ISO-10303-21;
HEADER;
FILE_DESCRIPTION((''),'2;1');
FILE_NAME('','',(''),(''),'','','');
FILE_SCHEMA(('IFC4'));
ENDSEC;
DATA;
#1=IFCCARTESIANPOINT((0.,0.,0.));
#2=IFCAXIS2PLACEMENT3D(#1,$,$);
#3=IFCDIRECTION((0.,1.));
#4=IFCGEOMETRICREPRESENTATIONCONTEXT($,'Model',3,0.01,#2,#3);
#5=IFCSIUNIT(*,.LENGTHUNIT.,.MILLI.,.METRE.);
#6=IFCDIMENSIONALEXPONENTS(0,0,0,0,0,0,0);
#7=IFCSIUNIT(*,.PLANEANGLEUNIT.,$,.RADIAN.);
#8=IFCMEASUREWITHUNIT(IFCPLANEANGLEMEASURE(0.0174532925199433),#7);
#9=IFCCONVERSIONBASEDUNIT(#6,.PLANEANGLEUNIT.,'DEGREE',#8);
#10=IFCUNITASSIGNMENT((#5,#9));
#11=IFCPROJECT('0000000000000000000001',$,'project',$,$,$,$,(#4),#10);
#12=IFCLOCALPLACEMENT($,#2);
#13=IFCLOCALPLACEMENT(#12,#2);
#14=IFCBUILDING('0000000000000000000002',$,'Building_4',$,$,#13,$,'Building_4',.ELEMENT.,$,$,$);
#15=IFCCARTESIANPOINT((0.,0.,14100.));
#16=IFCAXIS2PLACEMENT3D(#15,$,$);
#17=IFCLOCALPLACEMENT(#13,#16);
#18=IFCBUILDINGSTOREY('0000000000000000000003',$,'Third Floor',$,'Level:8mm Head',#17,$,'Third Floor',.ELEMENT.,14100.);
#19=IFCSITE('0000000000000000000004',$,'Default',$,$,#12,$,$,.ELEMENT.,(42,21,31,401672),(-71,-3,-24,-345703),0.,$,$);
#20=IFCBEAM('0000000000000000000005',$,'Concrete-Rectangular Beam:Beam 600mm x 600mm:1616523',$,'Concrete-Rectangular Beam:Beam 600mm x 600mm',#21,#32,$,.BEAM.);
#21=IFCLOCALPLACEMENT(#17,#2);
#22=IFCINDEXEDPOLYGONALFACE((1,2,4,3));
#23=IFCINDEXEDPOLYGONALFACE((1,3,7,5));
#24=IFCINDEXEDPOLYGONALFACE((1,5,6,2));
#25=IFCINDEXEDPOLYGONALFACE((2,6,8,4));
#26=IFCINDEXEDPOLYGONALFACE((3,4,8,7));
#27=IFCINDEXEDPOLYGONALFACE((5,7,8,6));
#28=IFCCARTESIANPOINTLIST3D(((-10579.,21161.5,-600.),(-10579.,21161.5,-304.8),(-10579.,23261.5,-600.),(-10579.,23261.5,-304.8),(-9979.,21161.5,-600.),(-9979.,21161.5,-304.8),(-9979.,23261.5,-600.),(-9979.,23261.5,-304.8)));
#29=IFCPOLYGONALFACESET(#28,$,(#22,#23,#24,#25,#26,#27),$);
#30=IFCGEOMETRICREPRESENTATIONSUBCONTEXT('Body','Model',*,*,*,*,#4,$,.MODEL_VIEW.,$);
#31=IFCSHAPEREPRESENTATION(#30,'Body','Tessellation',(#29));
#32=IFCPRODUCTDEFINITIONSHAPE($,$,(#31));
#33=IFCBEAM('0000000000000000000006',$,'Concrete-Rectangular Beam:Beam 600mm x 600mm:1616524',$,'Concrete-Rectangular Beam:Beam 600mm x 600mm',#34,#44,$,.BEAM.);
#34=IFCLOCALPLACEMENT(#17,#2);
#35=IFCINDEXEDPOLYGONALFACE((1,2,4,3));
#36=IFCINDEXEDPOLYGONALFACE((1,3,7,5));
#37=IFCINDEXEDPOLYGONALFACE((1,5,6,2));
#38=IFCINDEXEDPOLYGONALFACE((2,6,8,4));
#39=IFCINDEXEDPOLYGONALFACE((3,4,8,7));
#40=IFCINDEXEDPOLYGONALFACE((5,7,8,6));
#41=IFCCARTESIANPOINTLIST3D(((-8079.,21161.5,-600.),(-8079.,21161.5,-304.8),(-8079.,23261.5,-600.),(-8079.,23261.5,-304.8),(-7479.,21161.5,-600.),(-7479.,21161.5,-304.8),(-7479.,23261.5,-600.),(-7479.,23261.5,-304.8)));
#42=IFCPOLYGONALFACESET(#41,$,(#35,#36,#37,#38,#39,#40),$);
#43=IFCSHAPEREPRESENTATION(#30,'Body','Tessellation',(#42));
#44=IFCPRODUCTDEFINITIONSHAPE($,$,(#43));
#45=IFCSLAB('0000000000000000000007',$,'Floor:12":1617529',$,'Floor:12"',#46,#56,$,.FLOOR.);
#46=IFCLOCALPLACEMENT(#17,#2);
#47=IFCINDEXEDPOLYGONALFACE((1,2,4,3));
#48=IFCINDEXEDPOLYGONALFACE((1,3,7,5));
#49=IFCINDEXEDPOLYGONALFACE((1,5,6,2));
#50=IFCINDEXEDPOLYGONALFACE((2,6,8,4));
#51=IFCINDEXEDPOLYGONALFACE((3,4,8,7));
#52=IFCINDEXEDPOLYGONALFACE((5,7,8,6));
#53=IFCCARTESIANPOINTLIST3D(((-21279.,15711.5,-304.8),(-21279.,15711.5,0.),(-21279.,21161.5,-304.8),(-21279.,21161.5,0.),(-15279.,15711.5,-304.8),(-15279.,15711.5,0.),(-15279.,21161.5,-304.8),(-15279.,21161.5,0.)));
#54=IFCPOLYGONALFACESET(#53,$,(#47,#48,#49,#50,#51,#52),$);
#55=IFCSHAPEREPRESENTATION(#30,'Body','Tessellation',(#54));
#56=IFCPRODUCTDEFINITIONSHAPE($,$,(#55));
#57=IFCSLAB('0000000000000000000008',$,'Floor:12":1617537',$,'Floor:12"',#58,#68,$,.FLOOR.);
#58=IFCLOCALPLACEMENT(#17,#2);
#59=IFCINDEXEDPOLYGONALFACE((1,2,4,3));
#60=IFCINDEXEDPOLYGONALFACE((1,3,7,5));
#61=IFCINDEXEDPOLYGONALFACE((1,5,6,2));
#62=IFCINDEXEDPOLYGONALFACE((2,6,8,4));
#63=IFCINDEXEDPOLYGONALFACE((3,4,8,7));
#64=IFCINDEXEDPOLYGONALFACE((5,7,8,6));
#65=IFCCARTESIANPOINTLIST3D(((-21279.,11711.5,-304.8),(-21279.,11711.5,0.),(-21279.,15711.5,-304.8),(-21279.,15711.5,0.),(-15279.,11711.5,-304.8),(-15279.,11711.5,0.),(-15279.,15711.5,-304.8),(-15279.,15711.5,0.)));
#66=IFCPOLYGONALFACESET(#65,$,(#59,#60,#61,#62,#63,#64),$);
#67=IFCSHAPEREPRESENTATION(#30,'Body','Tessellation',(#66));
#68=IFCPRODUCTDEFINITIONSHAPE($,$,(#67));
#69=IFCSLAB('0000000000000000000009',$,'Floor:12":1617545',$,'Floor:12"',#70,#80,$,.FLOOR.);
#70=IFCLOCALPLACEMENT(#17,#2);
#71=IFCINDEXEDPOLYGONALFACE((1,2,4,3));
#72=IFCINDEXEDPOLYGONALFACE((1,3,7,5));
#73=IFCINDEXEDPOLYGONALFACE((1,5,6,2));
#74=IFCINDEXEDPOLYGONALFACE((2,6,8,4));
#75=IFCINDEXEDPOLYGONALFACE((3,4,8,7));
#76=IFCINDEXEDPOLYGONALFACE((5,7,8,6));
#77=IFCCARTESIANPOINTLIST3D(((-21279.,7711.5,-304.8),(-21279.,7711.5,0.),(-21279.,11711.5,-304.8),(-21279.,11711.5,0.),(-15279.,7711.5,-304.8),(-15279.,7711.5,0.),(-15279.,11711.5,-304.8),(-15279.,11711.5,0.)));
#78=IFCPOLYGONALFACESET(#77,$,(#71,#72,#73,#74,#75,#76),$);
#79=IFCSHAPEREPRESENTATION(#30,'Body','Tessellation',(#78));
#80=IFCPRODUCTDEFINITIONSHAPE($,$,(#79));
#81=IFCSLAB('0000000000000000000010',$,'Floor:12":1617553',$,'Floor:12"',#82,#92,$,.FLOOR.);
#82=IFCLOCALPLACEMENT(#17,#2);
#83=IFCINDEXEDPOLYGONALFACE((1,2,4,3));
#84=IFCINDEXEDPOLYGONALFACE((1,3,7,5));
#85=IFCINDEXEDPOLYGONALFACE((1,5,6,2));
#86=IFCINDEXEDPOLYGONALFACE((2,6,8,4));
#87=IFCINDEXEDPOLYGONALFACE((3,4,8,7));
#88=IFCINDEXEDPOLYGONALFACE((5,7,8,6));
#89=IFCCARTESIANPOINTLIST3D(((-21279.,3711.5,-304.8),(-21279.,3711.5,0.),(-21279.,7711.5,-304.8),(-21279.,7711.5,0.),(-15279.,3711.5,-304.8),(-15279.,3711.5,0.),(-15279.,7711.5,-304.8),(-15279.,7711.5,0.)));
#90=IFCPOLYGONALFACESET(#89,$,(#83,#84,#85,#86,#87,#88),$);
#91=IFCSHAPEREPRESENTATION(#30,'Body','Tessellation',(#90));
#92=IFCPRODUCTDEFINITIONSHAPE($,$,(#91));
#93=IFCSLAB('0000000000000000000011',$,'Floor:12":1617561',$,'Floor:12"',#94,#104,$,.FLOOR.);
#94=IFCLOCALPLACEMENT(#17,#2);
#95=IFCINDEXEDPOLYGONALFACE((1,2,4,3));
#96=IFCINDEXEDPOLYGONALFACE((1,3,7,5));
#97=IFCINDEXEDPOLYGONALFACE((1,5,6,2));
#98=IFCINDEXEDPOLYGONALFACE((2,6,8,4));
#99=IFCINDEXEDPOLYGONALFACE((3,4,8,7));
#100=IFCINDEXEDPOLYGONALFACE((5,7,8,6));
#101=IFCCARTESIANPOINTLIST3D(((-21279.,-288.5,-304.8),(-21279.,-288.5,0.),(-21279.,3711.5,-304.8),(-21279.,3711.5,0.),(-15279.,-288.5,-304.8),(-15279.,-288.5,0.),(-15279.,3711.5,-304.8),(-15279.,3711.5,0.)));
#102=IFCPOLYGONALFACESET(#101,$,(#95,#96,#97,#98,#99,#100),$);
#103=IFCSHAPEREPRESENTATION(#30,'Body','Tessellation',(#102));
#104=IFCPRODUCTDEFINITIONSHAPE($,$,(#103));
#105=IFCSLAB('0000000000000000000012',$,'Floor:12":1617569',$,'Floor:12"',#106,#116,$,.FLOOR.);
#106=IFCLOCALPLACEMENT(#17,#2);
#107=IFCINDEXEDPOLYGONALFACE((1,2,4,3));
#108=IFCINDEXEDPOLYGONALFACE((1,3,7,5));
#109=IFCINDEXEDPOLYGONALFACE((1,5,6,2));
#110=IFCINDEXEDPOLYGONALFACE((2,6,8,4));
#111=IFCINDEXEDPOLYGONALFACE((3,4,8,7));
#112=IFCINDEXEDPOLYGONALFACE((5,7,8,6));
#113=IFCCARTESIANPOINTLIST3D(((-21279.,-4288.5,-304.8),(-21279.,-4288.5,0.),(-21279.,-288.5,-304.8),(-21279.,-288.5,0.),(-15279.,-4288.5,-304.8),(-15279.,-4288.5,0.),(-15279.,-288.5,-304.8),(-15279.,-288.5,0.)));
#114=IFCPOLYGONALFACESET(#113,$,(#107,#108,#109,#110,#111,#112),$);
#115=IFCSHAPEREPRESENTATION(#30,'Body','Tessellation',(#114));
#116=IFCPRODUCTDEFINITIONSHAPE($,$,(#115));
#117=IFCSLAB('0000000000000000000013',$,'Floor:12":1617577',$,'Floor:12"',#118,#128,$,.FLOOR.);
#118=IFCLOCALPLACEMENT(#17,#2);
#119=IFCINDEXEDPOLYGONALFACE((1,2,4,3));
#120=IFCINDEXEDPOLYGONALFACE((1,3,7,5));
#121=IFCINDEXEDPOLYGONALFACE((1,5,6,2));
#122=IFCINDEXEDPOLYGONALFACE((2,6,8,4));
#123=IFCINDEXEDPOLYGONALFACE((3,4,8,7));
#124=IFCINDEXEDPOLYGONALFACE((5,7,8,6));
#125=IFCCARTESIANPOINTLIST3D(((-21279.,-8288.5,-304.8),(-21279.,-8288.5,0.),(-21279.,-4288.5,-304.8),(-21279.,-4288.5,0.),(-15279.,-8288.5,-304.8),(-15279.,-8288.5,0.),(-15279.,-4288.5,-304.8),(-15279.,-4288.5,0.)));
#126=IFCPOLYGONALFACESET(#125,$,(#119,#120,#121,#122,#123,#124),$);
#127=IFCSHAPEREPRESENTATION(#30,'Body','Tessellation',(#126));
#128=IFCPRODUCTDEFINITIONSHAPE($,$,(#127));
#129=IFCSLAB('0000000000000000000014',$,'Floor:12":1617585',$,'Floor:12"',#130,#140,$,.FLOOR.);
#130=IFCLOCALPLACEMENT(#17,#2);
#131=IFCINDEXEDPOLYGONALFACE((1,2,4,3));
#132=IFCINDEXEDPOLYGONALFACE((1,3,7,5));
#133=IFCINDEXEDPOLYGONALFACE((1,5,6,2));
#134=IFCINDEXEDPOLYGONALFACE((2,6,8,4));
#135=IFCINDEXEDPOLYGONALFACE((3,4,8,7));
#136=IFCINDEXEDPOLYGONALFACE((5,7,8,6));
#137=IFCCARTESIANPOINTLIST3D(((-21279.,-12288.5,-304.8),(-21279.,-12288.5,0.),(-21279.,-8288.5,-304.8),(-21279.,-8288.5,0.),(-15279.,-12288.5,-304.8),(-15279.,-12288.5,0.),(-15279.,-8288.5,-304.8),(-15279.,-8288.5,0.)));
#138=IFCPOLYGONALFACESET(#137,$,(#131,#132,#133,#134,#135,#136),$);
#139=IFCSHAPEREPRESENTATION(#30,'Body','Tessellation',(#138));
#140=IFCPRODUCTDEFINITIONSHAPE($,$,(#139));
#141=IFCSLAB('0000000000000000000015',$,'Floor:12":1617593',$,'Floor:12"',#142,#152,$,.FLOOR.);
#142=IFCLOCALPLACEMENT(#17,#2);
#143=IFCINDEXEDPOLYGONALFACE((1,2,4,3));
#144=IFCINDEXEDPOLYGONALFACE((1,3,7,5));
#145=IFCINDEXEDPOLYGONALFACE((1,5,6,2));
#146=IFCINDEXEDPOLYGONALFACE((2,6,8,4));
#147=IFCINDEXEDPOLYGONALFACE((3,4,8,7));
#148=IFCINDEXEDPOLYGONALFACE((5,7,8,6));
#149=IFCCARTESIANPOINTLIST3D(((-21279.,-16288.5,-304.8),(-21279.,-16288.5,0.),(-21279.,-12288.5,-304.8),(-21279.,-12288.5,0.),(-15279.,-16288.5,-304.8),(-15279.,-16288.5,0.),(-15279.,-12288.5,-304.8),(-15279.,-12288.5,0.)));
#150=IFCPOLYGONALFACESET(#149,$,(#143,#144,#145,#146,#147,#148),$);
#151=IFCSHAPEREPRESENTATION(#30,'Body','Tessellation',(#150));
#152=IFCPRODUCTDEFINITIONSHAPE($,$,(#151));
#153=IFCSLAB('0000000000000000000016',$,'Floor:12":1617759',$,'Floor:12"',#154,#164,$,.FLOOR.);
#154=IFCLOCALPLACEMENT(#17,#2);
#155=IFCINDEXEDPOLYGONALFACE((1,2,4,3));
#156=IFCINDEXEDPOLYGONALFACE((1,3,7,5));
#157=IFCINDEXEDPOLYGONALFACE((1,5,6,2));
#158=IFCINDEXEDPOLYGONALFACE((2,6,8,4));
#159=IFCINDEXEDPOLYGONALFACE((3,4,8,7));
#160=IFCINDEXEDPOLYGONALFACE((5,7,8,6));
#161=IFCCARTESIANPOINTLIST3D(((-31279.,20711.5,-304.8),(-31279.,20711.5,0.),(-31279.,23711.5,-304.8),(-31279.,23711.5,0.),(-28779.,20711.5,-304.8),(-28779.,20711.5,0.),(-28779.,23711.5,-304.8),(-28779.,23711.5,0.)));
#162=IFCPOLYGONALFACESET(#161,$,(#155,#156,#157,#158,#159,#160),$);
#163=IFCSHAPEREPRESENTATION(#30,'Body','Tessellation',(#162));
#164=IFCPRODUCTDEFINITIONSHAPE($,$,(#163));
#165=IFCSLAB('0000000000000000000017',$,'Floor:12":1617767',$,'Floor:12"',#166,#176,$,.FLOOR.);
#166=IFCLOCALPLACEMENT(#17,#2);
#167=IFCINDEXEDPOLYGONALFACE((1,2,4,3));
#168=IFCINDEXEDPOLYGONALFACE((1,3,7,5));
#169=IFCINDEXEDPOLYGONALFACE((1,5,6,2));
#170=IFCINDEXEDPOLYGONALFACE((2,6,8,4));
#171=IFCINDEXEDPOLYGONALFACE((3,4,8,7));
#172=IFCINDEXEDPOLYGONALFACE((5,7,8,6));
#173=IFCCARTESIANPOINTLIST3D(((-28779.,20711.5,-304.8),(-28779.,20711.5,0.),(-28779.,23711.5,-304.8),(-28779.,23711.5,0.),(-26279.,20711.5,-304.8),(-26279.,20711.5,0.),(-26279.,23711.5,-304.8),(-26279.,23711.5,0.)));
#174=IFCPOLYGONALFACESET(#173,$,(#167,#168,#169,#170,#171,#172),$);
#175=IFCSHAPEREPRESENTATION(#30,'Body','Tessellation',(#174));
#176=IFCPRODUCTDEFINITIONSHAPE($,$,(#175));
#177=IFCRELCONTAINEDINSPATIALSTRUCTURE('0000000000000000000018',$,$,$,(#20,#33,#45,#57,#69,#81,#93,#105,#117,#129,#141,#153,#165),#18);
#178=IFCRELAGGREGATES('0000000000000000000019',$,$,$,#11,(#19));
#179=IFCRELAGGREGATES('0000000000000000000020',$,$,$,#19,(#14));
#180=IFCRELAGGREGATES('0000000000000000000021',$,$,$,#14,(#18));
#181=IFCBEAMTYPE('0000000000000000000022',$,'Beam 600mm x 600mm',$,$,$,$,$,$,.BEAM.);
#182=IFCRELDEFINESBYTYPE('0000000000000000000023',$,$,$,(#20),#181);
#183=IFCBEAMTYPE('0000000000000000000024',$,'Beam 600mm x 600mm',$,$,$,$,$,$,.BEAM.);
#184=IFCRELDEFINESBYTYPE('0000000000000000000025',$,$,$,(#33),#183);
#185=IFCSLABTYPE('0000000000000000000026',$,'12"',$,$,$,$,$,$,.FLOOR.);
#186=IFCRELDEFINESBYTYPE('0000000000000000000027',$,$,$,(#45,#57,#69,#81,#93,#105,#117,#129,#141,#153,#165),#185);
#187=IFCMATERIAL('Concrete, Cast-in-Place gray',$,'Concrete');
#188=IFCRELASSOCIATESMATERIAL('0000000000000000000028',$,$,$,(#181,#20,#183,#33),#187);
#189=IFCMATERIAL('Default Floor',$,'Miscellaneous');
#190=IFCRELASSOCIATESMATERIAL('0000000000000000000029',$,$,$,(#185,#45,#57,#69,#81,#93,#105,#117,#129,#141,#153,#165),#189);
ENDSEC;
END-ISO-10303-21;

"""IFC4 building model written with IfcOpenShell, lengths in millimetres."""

from ifc_helpers import new_model, entity, si_unit, converted_unit, direction, frame, origin, place, context, subcontext, project, spatial, indexed_curve, outline, extrude, source, transform, mapped, material, type_object, type_shapes, element, save


model = new_model("IFC4")

# Units and contexts
model_context = context("Model", 3, precision=0.01, world=origin(), true_north=direction((0.0, 1.0)))
body_context = subcontext(model_context, "Body", "Model", "MODEL_VIEW")
ifc_project = project(units=[si_unit("LENGTHUNIT", "METRE", prefix="MILLI"), converted_unit("PLANEANGLEUNIT", "DEGREE", entity("IfcPlaneAngleMeasure", 0.0174532925199433), si_unit("PLANEANGLEUNIT", "RADIAN"), dimensions=[0, 0, 0, 0, 0, 0, 0])], contexts=[model_context])

# Site, building, storey
site_placement = place(None, origin())
site = spatial("IfcSite", under=ifc_project, at=site_placement, Name="Default", CompositionType="ELEMENT", RefLatitude=(42, 21, 31, 401672), RefLongitude=(-71, -3, -24, -345703), RefElevation=0.0)
building_placement = place(site_placement, origin())
building = spatial("IfcBuilding", under=site, at=building_placement, Name="Building_4", LongName="Building_4", CompositionType="ELEMENT")
storey_placement = place(building_placement, frame((0.0, 0.0, 14100.0)))
storey = spatial("IfcBuildingStorey", under=building, at=storey_placement, Name="Third Floor", ObjectType="Level:8mm Head", LongName="Third Floor", CompositionType="ELEMENT", Elevation=14100.0)

# Beams
ifc_material_1 = material(Name="Concrete, Cast-in-Place gray", Category="Concrete")
beam_type_1 = type_object("IfcBeamType", Name="Beam 600mm x 600mm", PredefinedType="BEAM", material=ifc_material_1)
shared_shape_1 = source(origin(), body_context, "Body", "SweptSolid", [
    extrude(outline(indexed_curve([(-300.0, -147.6), (300.0, -147.6), (300.0, 147.6), (-300.0, 147.6), (-300.0, -147.6)], self_intersect=False)), frame((-10279.0, 23261.5, 13647.6), z_axis=(0.0, -1.0, 0.0), x_axis=(-1.0, 0.0, 0.0)), (0.0, 0.0, 1.0), 2100.0),
])
type_shapes(beam_type_1, [shared_shape_1])
beam_1_placement = place(storey_placement, frame((0.0, 0.0, -14100.0)))
element("IfcBeam", 1, at=beam_1_placement, inside=storey, type_object=beam_type_1, material=ifc_material_1, Name="Concrete-Rectangular Beam:Beam 600mm x 600mm:1616523", ObjectType="Concrete-Rectangular Beam:Beam 600mm x 600mm", PredefinedType="BEAM", context=body_context, shape_type="MappedRepresentation", body=[
    mapped(shared_shape_1, transform((0.0, 0.0, 0.0), scale=1.0)),
])
beam_type_2 = type_object("IfcBeamType", Name="Beam 600mm x 600mm", PredefinedType="BEAM", material=ifc_material_1)
shared_shape_2 = source(origin(), body_context, "Body", "SweptSolid", [
    extrude(outline(indexed_curve([(-300.0, -147.6), (300.0, -147.6), (300.0, 147.6), (-300.0, 147.6), (-300.0, -147.6)], self_intersect=False)), frame((-7779.0, 23261.5, 13647.6), z_axis=(0.0, -1.0, 0.0), x_axis=(-1.0, 0.0, 0.0)), (0.0, 0.0, 1.0), 2100.0),
])
type_shapes(beam_type_2, [shared_shape_2])
beam_2_placement = place(storey_placement, frame((0.0, 0.0, -14100.0)))
element("IfcBeam", 2, at=beam_2_placement, inside=storey, type_object=beam_type_2, material=ifc_material_1, Name="Concrete-Rectangular Beam:Beam 600mm x 600mm:1616524", ObjectType="Concrete-Rectangular Beam:Beam 600mm x 600mm", PredefinedType="BEAM", context=body_context, shape_type="MappedRepresentation", body=[
    mapped(shared_shape_2, transform((0.0, 0.0, 0.0), scale=1.0)),
])

# Slabs
ifc_material_2 = material(Name="Default Floor", Category="Miscellaneous")
slab_type = type_object("IfcSlabType", Name="12\"", PredefinedType="FLOOR", material=ifc_material_2)
slab_1_placement = place(storey_placement, origin())
element("IfcSlab", 3, at=slab_1_placement, inside=storey, type_object=slab_type, material=ifc_material_2, Name="Floor:12\":1617529", ObjectType="Floor:12\"", PredefinedType="FLOOR", context=body_context, shape_type="SweptSolid", body=[
    extrude(outline(indexed_curve([(-2725.0, -3000.0), (2725.0, -3000.0), (2725.0, 3000.0), (-2725.0, 3000.0), (-2725.0, -3000.0)], self_intersect=False)), frame((-18279.0, 18436.5, 0.0), z_axis=(0.0, 0.0, -1.0), x_axis=(0.0, 1.0, 0.0)), (0.0, 0.0, 1.0), 304.8),
])
slab_2_placement = place(storey_placement, origin())
element("IfcSlab", 4, at=slab_2_placement, inside=storey, type_object=slab_type, material=ifc_material_2, Name="Floor:12\":1617537", ObjectType="Floor:12\"", PredefinedType="FLOOR", context=body_context, shape_type="SweptSolid", body=[
    extrude(outline(indexed_curve([(-2000.0, -3000.0), (2000.0, -3000.0), (2000.0, 3000.0), (-2000.0, 3000.0), (-2000.0, -3000.0)], self_intersect=False)), frame((-18279.0, 13711.5, 0.0), z_axis=(0.0, 0.0, -1.0), x_axis=(0.0, 1.0, 0.0)), (0.0, 0.0, 1.0), 304.8),
])
slab_3_placement = place(storey_placement, origin())
element("IfcSlab", 5, at=slab_3_placement, inside=storey, type_object=slab_type, material=ifc_material_2, Name="Floor:12\":1617545", ObjectType="Floor:12\"", PredefinedType="FLOOR", context=body_context, shape_type="SweptSolid", body=[
    extrude(outline(indexed_curve([(-2000.0, -3000.0), (2000.0, -3000.0), (2000.0, 3000.0), (-2000.0, 3000.0), (-2000.0, -3000.0)], self_intersect=False)), frame((-18279.0, 9711.5, 0.0), z_axis=(0.0, 0.0, -1.0), x_axis=(0.0, 1.0, 0.0)), (0.0, 0.0, 1.0), 304.8),
])
slab_4_placement = place(storey_placement, origin())
element("IfcSlab", 6, at=slab_4_placement, inside=storey, type_object=slab_type, material=ifc_material_2, Name="Floor:12\":1617553", ObjectType="Floor:12\"", PredefinedType="FLOOR", context=body_context, shape_type="SweptSolid", body=[
    extrude(outline(indexed_curve([(-2000.0, -3000.0), (2000.0, -3000.0), (2000.0, 3000.0), (-2000.0, 3000.0), (-2000.0, -3000.0)], self_intersect=False)), frame((-18279.0, 5711.5, 0.0), z_axis=(0.0, 0.0, -1.0), x_axis=(0.0, 1.0, 0.0)), (0.0, 0.0, 1.0), 304.8),
])
slab_5_placement = place(storey_placement, origin())
element("IfcSlab", 7, at=slab_5_placement, inside=storey, type_object=slab_type, material=ifc_material_2, Name="Floor:12\":1617561", ObjectType="Floor:12\"", PredefinedType="FLOOR", context=body_context, shape_type="SweptSolid", body=[
    extrude(outline(indexed_curve([(-2000.0, -3000.0), (2000.0, -3000.0), (2000.0, 3000.0), (-2000.0, 3000.0), (-2000.0, -3000.0)], self_intersect=False)), frame((-18279.0, 1711.5, 0.0), z_axis=(0.0, 0.0, -1.0), x_axis=(0.0, 1.0, 0.0)), (0.0, 0.0, 1.0), 304.8),
])
slab_6_placement = place(storey_placement, origin())
element("IfcSlab", 8, at=slab_6_placement, inside=storey, type_object=slab_type, material=ifc_material_2, Name="Floor:12\":1617569", ObjectType="Floor:12\"", PredefinedType="FLOOR", context=body_context, shape_type="SweptSolid", body=[
    extrude(outline(indexed_curve([(-2000.0, -3000.0), (2000.0, -3000.0), (2000.0, 3000.0), (-2000.0, 3000.0), (-2000.0, -3000.0)], self_intersect=False)), frame((-18279.0, -2288.5, 0.0), z_axis=(0.0, 0.0, -1.0), x_axis=(0.0, 1.0, 0.0)), (0.0, 0.0, 1.0), 304.8),
])
slab_7_placement = place(storey_placement, origin())
element("IfcSlab", 9, at=slab_7_placement, inside=storey, type_object=slab_type, material=ifc_material_2, Name="Floor:12\":1617577", ObjectType="Floor:12\"", PredefinedType="FLOOR", context=body_context, shape_type="SweptSolid", body=[
    extrude(outline(indexed_curve([(-2000.0, -3000.0), (2000.0, -3000.0), (2000.0, 3000.0), (-2000.0, 3000.0), (-2000.0, -3000.0)], self_intersect=False)), frame((-18279.0, -6288.5, 0.0), z_axis=(0.0, 0.0, -1.0), x_axis=(0.0, 1.0, 0.0)), (0.0, 0.0, 1.0), 304.8),
])
slab_8_placement = place(storey_placement, origin())
element("IfcSlab", 10, at=slab_8_placement, inside=storey, type_object=slab_type, material=ifc_material_2, Name="Floor:12\":1617585", ObjectType="Floor:12\"", PredefinedType="FLOOR", context=body_context, shape_type="SweptSolid", body=[
    extrude(outline(indexed_curve([(-2000.0, -3000.0), (2000.0, -3000.0), (2000.0, 3000.0), (-2000.0, 3000.0), (-2000.0, -3000.0)], self_intersect=False)), frame((-18279.0, -10288.5, 0.0), z_axis=(0.0, 0.0, -1.0), x_axis=(0.0, 1.0, 0.0)), (0.0, 0.0, 1.0), 304.8),
])
slab_9_placement = place(storey_placement, origin())
element("IfcSlab", 11, at=slab_9_placement, inside=storey, type_object=slab_type, material=ifc_material_2, Name="Floor:12\":1617593", ObjectType="Floor:12\"", PredefinedType="FLOOR", context=body_context, shape_type="SweptSolid", body=[
    extrude(outline(indexed_curve([(-2000.0, -3000.0), (2000.0, -3000.0), (2000.0, 3000.0), (-2000.0, 3000.0), (-2000.0, -3000.0)], self_intersect=False)), frame((-18279.0, -14288.5, 0.0), z_axis=(0.0, 0.0, -1.0), x_axis=(0.0, 1.0, 0.0)), (0.0, 0.0, 1.0), 304.8),
])
slab_10_placement = place(storey_placement, origin())
element("IfcSlab", 12, at=slab_10_placement, inside=storey, type_object=slab_type, material=ifc_material_2, Name="Floor:12\":1617759", ObjectType="Floor:12\"", PredefinedType="FLOOR", context=body_context, shape_type="SweptSolid", body=[
    extrude(outline(indexed_curve([(-1500.0, -1250.0), (1500.0, -1250.0), (1500.0, 1250.0), (-1500.0, 1250.0), (-1500.0, -1250.0)], self_intersect=False)), frame((-30029.0, 22211.5, 0.0), z_axis=(0.0, 0.0, -1.0), x_axis=(0.0, 1.0, 0.0)), (0.0, 0.0, 1.0), 304.8),
])
slab_11_placement = place(storey_placement, origin())
element("IfcSlab", 13, at=slab_11_placement, inside=storey, type_object=slab_type, material=ifc_material_2, Name="Floor:12\":1617767", ObjectType="Floor:12\"", PredefinedType="FLOOR", context=body_context, shape_type="SweptSolid", body=[
    extrude(outline(indexed_curve([(-1500.0, -1250.0), (1500.0, -1250.0), (1500.0, 1250.0), (-1500.0, 1250.0), (-1500.0, -1250.0)], self_intersect=False)), frame((-27529.0, 22211.5, 0.0), z_axis=(0.0, 0.0, -1.0), x_axis=(0.0, 1.0, 0.0)), (0.0, 0.0, 1.0), 304.8),
])

save(model, "model.ifc")
